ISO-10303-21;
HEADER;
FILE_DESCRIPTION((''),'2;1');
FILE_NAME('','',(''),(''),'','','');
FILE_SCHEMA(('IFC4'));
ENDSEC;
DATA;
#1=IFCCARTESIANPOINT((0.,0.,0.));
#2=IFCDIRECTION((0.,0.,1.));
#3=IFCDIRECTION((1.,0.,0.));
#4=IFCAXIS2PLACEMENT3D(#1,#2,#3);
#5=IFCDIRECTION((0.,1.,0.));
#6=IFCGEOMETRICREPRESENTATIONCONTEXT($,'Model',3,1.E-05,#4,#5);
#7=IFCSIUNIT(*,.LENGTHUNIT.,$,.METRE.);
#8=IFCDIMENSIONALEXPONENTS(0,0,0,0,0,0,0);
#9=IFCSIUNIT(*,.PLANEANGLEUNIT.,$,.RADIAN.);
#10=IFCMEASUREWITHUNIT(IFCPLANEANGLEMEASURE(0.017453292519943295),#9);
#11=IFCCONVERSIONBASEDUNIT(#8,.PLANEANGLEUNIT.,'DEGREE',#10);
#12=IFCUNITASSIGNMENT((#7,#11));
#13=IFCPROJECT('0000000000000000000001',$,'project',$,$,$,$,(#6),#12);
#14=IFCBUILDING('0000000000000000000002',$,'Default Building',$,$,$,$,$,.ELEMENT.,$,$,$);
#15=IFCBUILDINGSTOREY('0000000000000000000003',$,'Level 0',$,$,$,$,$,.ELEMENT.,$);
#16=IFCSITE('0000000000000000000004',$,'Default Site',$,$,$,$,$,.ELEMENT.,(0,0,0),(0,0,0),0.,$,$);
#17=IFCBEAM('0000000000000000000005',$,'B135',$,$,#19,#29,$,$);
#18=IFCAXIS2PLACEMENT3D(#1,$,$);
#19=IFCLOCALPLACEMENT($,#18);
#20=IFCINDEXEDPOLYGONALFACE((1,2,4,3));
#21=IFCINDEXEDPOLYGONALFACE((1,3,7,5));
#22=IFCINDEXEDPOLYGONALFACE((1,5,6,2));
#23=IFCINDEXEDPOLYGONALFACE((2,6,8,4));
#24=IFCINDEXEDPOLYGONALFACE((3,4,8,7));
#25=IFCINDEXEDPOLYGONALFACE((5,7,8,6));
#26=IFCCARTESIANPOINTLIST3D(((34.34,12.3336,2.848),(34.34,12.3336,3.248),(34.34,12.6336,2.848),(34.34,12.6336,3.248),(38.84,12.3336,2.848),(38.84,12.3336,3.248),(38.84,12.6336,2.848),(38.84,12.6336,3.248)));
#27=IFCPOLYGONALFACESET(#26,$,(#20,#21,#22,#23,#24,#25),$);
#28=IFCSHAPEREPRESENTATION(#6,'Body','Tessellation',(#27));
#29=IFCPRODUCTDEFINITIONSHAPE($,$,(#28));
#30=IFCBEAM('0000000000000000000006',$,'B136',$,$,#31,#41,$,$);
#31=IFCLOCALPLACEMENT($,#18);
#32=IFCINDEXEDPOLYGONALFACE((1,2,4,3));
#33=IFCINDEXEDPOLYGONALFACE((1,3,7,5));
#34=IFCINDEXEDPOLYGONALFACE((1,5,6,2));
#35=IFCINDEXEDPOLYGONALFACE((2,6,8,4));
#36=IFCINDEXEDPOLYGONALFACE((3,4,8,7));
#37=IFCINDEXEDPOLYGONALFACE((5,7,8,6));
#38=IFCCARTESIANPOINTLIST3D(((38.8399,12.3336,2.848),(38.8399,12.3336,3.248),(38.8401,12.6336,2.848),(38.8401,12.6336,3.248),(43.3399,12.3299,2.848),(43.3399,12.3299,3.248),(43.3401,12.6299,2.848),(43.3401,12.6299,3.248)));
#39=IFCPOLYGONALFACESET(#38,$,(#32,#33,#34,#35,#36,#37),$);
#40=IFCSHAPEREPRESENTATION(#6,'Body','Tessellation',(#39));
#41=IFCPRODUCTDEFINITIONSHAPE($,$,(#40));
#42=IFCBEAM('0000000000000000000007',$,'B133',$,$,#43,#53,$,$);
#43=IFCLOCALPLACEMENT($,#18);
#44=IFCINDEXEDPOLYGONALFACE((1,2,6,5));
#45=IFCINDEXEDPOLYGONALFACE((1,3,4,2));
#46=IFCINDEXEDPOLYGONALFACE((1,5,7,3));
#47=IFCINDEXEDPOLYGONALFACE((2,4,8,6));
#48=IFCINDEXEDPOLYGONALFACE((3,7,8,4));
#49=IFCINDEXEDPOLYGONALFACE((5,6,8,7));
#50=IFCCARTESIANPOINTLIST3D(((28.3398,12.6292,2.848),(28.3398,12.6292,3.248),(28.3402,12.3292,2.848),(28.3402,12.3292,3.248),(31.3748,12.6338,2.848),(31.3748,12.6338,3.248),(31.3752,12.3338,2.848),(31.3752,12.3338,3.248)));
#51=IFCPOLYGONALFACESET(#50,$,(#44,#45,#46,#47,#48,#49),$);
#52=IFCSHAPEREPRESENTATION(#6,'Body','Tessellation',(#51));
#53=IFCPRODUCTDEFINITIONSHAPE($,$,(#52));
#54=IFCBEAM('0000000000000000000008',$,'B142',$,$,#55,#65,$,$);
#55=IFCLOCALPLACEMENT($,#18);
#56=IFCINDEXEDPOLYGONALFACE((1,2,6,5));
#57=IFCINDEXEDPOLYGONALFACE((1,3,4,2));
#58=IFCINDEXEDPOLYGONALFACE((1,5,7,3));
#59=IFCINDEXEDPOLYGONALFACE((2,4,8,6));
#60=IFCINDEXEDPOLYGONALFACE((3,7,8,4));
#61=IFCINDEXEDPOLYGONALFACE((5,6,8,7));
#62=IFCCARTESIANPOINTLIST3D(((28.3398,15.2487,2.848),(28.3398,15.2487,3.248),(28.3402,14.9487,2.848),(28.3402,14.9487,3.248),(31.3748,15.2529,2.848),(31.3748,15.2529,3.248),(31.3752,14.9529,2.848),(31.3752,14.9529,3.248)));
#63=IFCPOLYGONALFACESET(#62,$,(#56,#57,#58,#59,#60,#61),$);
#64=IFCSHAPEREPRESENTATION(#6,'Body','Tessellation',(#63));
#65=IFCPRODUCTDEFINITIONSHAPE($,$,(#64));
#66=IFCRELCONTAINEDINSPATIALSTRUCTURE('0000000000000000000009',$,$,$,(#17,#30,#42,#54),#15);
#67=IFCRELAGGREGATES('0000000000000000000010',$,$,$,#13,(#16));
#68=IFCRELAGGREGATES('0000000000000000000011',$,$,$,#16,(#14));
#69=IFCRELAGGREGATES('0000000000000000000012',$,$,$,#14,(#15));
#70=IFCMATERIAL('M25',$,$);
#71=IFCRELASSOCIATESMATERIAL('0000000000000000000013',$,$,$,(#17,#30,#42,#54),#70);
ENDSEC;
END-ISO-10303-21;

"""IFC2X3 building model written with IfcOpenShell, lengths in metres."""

from ifc_helpers import new_model, entity, si_unit, converted_unit, direction, frame, frame_2d, origin_with_axes, place, context, project, spatial, rectangle, extrude, material, element, save


model = new_model("IFC2X3")

# Units and contexts
model_context = context("Model", 3, precision=1e-05, world=origin_with_axes(), true_north=direction((0.0, 1.0, 0.0)))
ifc_project = project(units=[si_unit("LENGTHUNIT", "METRE"), converted_unit("PLANEANGLEUNIT", "DEGREE", entity("IfcPlaneAngleMeasure", 0.017453292519943295), si_unit("PLANEANGLEUNIT", "RADIAN"), dimensions=[0, 0, 0, 0, 0, 0, 0])], contexts=[model_context])

# Site, building, storey
site = spatial("IfcSite", under=ifc_project, Name="Default Site", CompositionType="ELEMENT", RefLatitude=(0, 0, 0), RefLongitude=(0, 0, 0), RefElevation=0.0)
building = spatial("IfcBuilding", under=site, Name="Default Building", CompositionType="ELEMENT")
storey = spatial("IfcBuildingStorey", under=building, Name="Level 0", CompositionType="ELEMENT")

# Beams
ifc_material = material(Name="M25")
placement = place(None, origin_with_axes())
element("IfcBeam", 1, at=placement, inside=storey, material=ifc_material, Name="B135", context=model_context, shape_type="SweptSolid", body=[
    extrude(rectangle(XDim=0.3, YDim=0.4, at=frame_2d((0.0, 0.0), x_axis=(0.0, 1.0, 0.0))), frame((34.34, 12.4836, 3.048), z_axis=(1.0, -0.000008, 0.0), x_axis=(0.0, 0.0, -1.0)), (0.0, 0.0, 1.0), 4.5),
])
element("IfcBeam", 2, at=placement, inside=storey, material=ifc_material, Name="B136", context=model_context, shape_type="SweptSolid", body=[
    extrude(rectangle(XDim=0.3, YDim=0.4, at=frame_2d((0.0, 0.0), x_axis=(0.0, 1.0, 0.0))), frame((38.84, 12.4836, 3.048), z_axis=(1.0, -0.000826, 0.0), x_axis=(0.0, 0.0, -1.0)), (0.0, 0.0, 1.0), 4.5),
])
element("IfcBeam", 3, at=placement, inside=storey, material=ifc_material, Name="B133", context=model_context, shape_type="SweptSolid", body=[
    extrude(rectangle(XDim=0.3, YDim=0.4, at=frame_2d((0.0, 0.0), x_axis=(0.0, 1.0, 0.0))), frame((28.34, 12.4792, 3.048), z_axis=(0.999999, 0.001542, 0.0), x_axis=(0.0, 0.0, -1.0)), (0.0, 0.0, 1.0), 3.035),
])
element("IfcBeam", 4, at=placement, inside=storey, material=ifc_material, Name="B142", context=model_context, shape_type="SweptSolid", body=[
    extrude(rectangle(XDim=0.3, YDim=0.4, at=frame_2d((0.0, 0.0), x_axis=(0.0, 1.0, 0.0))), frame((31.375, 15.1029, 3.048), z_axis=(-0.999999, -0.001391, 0.0), x_axis=(0.0, 0.0, -1.0)), (0.0, 0.0, 1.0), 3.035),
])

save(model, "model.ifc")
